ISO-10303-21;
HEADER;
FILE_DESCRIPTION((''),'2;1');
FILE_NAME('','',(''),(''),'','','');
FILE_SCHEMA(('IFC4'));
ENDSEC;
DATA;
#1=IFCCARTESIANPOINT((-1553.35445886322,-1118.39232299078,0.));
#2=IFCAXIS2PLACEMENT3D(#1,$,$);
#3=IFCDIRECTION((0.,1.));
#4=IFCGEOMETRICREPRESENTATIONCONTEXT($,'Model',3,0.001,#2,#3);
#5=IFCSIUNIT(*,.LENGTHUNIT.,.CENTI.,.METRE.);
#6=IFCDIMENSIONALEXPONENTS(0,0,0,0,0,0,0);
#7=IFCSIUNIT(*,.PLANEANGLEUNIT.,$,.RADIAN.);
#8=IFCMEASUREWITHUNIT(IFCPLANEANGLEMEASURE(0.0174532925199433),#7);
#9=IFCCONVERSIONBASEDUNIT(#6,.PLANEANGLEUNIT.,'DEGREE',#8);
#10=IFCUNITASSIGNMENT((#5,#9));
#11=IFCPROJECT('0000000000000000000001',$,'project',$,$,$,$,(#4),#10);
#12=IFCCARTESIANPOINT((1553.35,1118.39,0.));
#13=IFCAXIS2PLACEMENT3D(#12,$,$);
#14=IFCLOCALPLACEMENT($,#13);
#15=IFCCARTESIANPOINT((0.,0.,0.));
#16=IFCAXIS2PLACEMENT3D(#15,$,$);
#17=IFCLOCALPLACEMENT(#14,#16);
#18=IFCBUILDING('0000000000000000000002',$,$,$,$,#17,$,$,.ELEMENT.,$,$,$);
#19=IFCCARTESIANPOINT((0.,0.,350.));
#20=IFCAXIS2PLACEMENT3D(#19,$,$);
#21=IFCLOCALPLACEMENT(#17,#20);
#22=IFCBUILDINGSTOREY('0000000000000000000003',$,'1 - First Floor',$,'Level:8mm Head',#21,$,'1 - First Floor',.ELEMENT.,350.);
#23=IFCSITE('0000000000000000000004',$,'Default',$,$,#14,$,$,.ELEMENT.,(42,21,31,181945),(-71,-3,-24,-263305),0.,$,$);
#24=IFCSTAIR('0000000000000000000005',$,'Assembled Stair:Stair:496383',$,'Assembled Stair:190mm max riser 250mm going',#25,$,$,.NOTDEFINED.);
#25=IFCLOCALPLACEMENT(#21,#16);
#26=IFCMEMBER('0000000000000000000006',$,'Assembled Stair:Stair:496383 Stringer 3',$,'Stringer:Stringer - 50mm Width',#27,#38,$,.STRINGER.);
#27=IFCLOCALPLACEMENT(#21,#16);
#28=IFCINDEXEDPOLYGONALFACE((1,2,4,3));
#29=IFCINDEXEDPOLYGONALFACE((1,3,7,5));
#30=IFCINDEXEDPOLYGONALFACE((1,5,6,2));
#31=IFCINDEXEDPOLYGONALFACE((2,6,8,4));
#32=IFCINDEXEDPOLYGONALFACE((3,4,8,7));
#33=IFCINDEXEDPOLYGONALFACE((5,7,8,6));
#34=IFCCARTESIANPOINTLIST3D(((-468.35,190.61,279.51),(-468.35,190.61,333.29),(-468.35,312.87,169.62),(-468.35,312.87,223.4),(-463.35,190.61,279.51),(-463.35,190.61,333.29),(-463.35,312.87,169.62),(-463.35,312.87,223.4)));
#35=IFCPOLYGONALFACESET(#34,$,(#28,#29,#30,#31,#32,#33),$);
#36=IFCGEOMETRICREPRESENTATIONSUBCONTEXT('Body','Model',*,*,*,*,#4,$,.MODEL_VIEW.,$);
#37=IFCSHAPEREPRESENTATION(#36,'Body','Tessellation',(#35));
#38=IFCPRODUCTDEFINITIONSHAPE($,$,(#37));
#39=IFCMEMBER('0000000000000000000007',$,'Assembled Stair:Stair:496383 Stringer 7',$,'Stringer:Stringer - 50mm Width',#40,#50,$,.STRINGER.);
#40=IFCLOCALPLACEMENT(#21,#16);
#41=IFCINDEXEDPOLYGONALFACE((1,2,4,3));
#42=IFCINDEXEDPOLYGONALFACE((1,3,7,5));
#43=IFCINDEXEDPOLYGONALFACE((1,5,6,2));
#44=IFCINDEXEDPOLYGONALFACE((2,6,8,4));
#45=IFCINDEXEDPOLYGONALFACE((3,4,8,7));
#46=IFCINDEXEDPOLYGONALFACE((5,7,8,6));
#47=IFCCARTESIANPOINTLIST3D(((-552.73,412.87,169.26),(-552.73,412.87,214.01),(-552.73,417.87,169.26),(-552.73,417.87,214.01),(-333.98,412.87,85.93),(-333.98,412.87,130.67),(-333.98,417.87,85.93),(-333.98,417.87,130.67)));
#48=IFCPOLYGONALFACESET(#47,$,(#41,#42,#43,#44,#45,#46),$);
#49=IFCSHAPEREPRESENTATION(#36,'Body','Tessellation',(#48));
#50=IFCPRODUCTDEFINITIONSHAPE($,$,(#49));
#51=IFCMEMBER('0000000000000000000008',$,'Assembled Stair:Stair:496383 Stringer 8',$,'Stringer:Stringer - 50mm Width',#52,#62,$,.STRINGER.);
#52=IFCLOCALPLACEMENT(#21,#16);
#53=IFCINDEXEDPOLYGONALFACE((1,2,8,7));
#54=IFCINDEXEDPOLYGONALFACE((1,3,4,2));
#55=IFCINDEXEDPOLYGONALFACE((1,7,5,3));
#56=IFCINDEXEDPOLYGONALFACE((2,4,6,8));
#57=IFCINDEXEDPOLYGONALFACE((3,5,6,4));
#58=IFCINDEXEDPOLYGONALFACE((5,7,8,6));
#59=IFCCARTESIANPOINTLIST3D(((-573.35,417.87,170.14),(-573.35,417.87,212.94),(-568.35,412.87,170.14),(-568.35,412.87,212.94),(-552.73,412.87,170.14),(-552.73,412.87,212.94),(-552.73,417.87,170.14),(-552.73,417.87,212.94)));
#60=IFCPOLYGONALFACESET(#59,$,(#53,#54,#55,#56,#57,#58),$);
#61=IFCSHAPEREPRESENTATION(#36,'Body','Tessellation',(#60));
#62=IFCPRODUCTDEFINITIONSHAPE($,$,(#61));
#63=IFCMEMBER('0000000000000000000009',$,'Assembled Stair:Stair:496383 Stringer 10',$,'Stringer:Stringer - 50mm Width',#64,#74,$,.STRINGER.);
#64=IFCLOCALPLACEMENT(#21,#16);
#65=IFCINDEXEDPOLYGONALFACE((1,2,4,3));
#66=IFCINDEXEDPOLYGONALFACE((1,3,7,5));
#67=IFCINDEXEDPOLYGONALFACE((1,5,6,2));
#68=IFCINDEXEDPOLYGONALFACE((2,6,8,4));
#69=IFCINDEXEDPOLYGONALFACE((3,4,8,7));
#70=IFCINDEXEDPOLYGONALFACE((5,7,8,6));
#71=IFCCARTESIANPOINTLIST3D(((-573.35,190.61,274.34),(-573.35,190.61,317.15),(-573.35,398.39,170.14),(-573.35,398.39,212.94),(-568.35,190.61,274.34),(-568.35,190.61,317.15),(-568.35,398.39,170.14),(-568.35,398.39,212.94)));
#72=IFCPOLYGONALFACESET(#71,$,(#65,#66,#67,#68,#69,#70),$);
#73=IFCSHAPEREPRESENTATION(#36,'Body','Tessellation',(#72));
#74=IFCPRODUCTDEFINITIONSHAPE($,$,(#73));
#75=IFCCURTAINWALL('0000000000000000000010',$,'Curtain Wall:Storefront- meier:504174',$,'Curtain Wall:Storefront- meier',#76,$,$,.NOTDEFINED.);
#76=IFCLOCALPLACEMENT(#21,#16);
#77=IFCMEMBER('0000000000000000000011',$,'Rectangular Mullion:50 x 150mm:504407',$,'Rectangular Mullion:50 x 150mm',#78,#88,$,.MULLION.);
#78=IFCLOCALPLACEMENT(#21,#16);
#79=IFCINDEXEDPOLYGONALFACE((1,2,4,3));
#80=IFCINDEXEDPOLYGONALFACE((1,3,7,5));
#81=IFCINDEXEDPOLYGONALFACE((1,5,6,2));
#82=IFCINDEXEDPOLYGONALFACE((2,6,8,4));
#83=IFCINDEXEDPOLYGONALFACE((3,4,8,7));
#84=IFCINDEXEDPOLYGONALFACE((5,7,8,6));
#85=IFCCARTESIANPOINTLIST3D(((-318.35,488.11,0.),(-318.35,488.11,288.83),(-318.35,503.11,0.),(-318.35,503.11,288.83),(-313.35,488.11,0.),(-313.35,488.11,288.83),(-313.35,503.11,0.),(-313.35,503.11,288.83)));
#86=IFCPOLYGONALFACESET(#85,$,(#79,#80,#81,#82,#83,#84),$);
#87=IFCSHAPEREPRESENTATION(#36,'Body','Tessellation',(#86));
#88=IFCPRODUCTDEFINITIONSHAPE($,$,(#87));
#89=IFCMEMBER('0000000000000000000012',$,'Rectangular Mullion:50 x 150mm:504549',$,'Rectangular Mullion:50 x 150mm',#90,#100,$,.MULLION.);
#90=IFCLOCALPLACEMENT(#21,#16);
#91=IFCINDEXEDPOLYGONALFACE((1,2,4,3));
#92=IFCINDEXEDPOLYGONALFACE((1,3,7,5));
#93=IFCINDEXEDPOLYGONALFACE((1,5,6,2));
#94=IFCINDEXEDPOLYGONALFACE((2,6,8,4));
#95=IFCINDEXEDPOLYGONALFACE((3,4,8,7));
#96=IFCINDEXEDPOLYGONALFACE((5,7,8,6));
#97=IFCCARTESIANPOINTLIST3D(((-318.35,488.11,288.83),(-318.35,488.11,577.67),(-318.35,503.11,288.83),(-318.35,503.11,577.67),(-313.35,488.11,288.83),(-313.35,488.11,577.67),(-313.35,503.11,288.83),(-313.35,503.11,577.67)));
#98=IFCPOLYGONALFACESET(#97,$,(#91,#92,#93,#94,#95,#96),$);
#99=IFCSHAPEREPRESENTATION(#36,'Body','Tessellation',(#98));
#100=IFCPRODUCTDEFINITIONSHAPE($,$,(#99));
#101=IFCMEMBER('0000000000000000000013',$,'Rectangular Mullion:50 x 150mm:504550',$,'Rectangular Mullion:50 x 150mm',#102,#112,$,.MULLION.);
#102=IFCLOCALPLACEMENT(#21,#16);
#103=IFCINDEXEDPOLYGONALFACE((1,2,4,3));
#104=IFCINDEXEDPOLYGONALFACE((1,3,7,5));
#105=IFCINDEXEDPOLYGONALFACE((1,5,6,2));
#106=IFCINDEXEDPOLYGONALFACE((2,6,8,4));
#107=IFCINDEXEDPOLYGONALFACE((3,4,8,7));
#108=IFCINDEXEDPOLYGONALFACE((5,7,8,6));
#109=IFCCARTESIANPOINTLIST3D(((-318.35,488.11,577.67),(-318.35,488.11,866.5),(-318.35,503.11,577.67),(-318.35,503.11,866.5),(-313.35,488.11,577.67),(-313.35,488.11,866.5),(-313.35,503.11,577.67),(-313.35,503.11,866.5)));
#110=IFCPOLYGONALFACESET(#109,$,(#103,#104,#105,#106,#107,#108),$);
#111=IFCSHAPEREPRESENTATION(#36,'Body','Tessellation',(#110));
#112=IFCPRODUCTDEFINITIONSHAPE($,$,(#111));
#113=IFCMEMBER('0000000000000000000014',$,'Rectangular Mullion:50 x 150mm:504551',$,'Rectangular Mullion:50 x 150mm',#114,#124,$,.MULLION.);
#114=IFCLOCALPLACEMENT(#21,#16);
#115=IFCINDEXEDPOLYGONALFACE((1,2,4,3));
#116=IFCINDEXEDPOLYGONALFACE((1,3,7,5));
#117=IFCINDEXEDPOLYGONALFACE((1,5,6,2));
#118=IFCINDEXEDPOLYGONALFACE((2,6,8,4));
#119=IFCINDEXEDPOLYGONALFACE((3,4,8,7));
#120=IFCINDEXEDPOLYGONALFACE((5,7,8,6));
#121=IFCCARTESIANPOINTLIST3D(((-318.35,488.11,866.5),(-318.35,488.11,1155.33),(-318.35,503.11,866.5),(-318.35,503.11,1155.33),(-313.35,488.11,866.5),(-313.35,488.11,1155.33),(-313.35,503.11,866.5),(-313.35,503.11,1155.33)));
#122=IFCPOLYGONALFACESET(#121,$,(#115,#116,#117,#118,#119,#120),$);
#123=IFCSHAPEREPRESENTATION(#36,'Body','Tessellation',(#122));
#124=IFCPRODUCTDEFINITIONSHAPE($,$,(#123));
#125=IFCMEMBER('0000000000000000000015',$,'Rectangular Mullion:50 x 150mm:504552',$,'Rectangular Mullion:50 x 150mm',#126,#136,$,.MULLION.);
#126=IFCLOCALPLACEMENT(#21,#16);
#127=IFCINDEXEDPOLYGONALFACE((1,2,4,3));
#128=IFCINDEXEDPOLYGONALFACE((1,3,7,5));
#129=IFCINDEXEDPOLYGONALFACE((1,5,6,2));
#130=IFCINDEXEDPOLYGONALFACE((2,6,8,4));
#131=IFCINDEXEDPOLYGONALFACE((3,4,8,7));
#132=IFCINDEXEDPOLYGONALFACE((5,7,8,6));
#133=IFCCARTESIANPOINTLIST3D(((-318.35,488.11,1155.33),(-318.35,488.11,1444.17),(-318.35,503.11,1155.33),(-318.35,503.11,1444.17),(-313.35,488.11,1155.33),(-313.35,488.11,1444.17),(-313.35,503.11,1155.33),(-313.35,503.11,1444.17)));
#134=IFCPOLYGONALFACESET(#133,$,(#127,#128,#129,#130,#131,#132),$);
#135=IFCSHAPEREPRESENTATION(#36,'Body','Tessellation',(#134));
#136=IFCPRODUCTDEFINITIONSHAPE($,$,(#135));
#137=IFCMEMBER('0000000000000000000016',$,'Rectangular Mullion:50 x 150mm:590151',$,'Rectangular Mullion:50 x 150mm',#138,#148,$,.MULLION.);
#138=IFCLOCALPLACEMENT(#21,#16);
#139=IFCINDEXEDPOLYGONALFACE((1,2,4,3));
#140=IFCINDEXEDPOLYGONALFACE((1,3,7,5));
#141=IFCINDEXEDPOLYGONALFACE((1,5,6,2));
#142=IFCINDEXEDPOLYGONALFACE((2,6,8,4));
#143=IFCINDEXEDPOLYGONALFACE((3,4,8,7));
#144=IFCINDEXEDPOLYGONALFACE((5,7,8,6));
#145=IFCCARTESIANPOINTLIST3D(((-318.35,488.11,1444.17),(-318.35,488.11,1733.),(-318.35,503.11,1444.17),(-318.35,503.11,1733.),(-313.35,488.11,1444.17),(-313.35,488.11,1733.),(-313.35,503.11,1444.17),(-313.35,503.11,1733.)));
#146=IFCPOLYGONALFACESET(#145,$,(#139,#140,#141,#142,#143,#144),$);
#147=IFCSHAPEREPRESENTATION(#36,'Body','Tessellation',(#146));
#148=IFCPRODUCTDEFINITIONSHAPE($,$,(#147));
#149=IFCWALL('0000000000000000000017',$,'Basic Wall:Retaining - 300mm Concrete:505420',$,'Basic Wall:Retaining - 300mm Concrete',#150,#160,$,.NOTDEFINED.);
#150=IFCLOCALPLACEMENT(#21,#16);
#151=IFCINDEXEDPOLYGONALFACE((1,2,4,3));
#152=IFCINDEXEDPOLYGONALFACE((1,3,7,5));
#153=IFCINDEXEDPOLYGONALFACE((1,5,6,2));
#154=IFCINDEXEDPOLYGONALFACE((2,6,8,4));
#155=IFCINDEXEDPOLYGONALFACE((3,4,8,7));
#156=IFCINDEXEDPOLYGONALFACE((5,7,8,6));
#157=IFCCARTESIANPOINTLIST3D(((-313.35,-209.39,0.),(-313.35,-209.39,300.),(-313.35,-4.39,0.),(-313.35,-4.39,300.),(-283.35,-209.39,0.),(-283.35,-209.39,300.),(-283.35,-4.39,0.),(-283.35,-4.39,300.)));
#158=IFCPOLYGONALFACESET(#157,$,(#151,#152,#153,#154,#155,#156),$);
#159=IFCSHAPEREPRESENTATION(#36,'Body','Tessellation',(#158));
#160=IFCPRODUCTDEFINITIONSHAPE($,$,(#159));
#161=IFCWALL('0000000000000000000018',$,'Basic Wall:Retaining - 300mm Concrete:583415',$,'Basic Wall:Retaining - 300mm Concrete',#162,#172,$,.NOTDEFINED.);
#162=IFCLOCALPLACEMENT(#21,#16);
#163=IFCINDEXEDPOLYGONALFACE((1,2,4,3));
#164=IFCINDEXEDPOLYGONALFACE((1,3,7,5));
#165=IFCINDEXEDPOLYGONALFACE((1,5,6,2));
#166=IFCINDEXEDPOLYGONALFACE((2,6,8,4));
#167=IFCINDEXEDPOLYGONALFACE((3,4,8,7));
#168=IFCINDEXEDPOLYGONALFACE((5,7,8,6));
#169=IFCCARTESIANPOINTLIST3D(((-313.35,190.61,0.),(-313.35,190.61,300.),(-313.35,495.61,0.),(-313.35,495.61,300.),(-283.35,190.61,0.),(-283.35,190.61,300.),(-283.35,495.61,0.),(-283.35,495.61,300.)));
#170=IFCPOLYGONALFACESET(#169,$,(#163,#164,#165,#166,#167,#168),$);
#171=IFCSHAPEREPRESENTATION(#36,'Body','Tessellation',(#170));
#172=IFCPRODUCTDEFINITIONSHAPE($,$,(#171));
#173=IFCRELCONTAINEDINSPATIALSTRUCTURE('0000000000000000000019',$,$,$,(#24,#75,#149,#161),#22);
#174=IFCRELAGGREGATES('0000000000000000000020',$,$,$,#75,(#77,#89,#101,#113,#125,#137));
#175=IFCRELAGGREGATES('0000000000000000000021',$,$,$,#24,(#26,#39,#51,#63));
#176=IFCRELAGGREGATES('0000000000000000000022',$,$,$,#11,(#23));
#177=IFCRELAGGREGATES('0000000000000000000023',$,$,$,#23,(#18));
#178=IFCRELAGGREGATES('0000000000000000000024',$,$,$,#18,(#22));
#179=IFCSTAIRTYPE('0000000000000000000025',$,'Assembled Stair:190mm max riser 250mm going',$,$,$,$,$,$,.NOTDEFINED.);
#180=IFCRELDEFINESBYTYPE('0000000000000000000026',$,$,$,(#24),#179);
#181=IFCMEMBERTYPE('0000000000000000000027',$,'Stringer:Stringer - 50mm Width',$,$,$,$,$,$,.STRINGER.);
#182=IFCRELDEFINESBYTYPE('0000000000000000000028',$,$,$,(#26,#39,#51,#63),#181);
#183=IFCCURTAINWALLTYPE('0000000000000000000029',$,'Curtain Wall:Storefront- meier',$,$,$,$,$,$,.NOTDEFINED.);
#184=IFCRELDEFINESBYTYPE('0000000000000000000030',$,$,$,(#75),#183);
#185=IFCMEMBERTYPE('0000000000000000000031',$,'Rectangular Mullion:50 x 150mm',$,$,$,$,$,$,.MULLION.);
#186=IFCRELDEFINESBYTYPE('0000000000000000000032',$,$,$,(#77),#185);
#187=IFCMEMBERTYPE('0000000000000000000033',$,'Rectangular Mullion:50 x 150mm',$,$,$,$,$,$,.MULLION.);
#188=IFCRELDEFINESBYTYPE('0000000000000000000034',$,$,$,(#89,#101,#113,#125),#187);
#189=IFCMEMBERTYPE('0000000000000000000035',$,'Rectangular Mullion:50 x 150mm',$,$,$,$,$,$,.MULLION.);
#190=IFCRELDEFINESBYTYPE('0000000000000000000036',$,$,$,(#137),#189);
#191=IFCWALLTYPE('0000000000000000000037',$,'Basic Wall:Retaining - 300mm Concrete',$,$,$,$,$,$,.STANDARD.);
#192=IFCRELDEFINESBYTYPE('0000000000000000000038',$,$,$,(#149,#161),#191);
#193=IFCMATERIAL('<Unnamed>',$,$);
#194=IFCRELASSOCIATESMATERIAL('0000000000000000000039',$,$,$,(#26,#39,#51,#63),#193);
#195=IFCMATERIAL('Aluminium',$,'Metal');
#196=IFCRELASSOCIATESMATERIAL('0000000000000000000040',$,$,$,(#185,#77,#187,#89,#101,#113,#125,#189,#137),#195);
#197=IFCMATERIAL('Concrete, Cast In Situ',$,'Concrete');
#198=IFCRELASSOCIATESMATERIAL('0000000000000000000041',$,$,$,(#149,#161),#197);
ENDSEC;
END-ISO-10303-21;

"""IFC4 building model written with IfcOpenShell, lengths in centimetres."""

from ifc_helpers import new_model, entity, si_unit, converted_unit, direction, frame, origin, place, context, subcontext, project, spatial, indexed_curve, outline, extrude, source, transform, mapped, material, type_object, type_shapes, element, aggregate, save


model = new_model("IFC4")

# Units and contexts
model_context = context("Model", 3, precision=0.001, world=frame((-1553.35445886322, -1118.39232299078, 0.0)), true_north=direction((0.0, 1.0)))
body_context = subcontext(model_context, "Body", "Model", "MODEL_VIEW")
ifc_project = project(units=[si_unit("LENGTHUNIT", "METRE", prefix="CENTI"), converted_unit("PLANEANGLEUNIT", "DEGREE", entity("IfcPlaneAngleMeasure", 0.0174532925199433), si_unit("PLANEANGLEUNIT", "RADIAN"), dimensions=[0, 0, 0, 0, 0, 0, 0])], contexts=[model_context])

# Site, building, storey
site_placement = place(None, frame((1553.35, 1118.39, 0.0)))
site = spatial("IfcSite", under=ifc_project, at=site_placement, Name="Default", CompositionType="ELEMENT", RefLatitude=(42, 21, 31, 181945), RefLongitude=(-71, -3, -24, -263305), RefElevation=0.0)
building_placement = place(site_placement, origin())
building = spatial("IfcBuilding", under=site, at=building_placement, CompositionType="ELEMENT")
storey_placement = place(building_placement, frame((0.0, 0.0, 350.0)))
storey = spatial("IfcBuildingStorey", under=building, at=storey_placement, Name="1 - First Floor", ObjectType="Level:8mm Head", LongName="1 - First Floor", CompositionType="ELEMENT", Elevation=350.0)

# Stair, members
stair_type = type_object("IfcStairType", Name="Assembled Stair:190mm max riser 250mm going", PredefinedType="NOTDEFINED")
stair_1_placement = place(storey_placement, origin())
stair_1 = element("IfcStair", 1, at=stair_1_placement, inside=storey, type_object=stair_type, Name="Assembled Stair:Stair:496383", ObjectType="Assembled Stair:190mm max riser 250mm going", PredefinedType="NOTDEFINED")
ifc_material_1 = material(Name="<Unnamed>")
member_type_1 = type_object("IfcMemberType", Name="Stringer:Stringer - 50mm Width", PredefinedType="STRINGER")
member_1_placement = place(stair_1_placement, origin())
member_1 = element("IfcMember", 2, at=member_1_placement, type_object=member_type_1, material=ifc_material_1, Name="Assembled Stair:Stair:496383 Stringer 3", ObjectType="Stringer:Stringer - 50mm Width", PredefinedType="STRINGER", context=body_context, shape_type="SweptSolid", body=[
    extrude(outline(indexed_curve([(-64.22, -20.0), (100.17, -20.0), (64.22, 20.0), (-100.17, 20.0), (-64.22, -20.0)], self_intersect=False)), frame((-468.35, 251.74, 251.46), z_axis=(1.0, 0.0, 0.0), x_axis=(0.0, -0.74373, 0.668481)), (0.0, 0.0, 1.0), 5.0),
])
member_2_placement = place(stair_1_placement, origin())
member_2 = element("IfcMember", 3, at=member_2_placement, type_object=member_type_1, material=ifc_material_1, Name="Assembled Stair:Stair:496383 Stringer 7", ObjectType="Stringer:Stringer - 50mm Width", PredefinedType="STRINGER", context=body_context, shape_type="SweptSolid", body=[
    extrude(outline(indexed_curve([(-125.01, -20.91), (109.08, -20.91), (125.01, 20.91), (-109.08, 20.91), (-125.01, -20.91)], self_intersect=False)), frame((-443.35, 412.87, 149.97), z_axis=(0.0, 1.0, 0.0), x_axis=(-0.934489, 0.0, 0.355992)), (0.0, 0.0, 1.0), 5.0),
])
member_3_placement = place(stair_1_placement, origin())
member_3 = element("IfcMember", 4, at=member_3_placement, type_object=member_type_1, material=ifc_material_1, Name="Assembled Stair:Stair:496383 Stringer 8", ObjectType="Stringer:Stringer - 50mm Width", PredefinedType="STRINGER", context=body_context, shape_type="SweptSolid", body=[
    extrude(outline(indexed_curve([(-9.06, -2.5), (11.56, -2.5), (6.56, 2.5), (-9.06, 2.5), (-9.06, -2.5)], self_intersect=False)), frame((-561.79, 415.37, 170.14), z_axis=(0.0, 0.0, 1.0), x_axis=(-1.0, 0.0, 0.0)), (0.0, 0.0, 1.0), 42.8),
])
member_4_placement = place(stair_1_placement, origin())
member_4 = element("IfcMember", 5, at=member_4_placement, type_object=member_type_1, material=ifc_material_1, Name="Assembled Stair:Stair:496383 Stringer 10", ObjectType="Stringer:Stringer - 50mm Width", PredefinedType="STRINGER", context=body_context, shape_type="SweptSolid", body=[
    extrude(outline(indexed_curve([(-106.63, -19.13), (125.82, -19.13), (106.63, 19.13), (-125.82, 19.13), (-106.63, -19.13)], self_intersect=False)), frame((-573.35, 294.5, 243.64), z_axis=(1.0, 0.0, 0.0), x_axis=(0.0, -0.893886, 0.448294)), (0.0, 0.0, 1.0), 5.0),
])

# Curtain wall, members
curtain_wall_type = type_object("IfcCurtainWallType", Name="Curtain Wall:Storefront- meier", PredefinedType="NOTDEFINED")
curtain_wall_placement = place(storey_placement, frame((0.0, 0.0, -350.0)))
curtain_wall = element("IfcCurtainWall", 6, at=curtain_wall_placement, inside=storey, type_object=curtain_wall_type, Name="Curtain Wall:Storefront- meier:504174", ObjectType="Curtain Wall:Storefront- meier", PredefinedType="NOTDEFINED")
ifc_material_2 = material(Name="Aluminium", Category="Metal")
member_type_2 = type_object("IfcMemberType", Name="Rectangular Mullion:50 x 150mm", PredefinedType="MULLION", material=ifc_material_2)
shared_shape_1 = source(origin(), body_context, "Body", "SweptSolid", [
    extrude(outline(indexed_curve([(-2.5, -7.5), (2.5, -7.5), (2.5, 7.5), (-2.5, 7.5), (-2.5, -7.5)], self_intersect=False)), frame((-2.5, 0.0, -288.83), z_axis=(0.0, 0.0, 1.0), x_axis=(-1.0, 0.0, 0.0)), (0.0, 0.0, 1.0), 288.83),
])
type_shapes(member_type_2, [shared_shape_1])
member_5_placement = place(curtain_wall_placement, frame((-313.35, 495.61, 350.0), z_axis=(0.0, 0.0, -1.0), x_axis=(1.0, 0.0, 0.0)))
member_5 = element("IfcMember", 7, at=member_5_placement, type_object=member_type_2, material=ifc_material_2, Name="Rectangular Mullion:50 x 150mm:504407", ObjectType="Rectangular Mullion:50 x 150mm", PredefinedType="MULLION", context=body_context, shape_type="MappedRepresentation", body=[
    mapped(shared_shape_1, transform((0.0, 0.0, 0.0), scale=1.0)),
])
member_type_3 = type_object("IfcMemberType", Name="Rectangular Mullion:50 x 150mm", PredefinedType="MULLION", material=ifc_material_2)
shared_shape_2 = source(origin(), body_context, "Body", "SweptSolid", [
    extrude(outline(indexed_curve([(-2.5, -7.5), (2.5, -7.5), (2.5, 7.5), (-2.5, 7.5), (-2.5, -7.5)], self_intersect=False)), frame((-2.5, 0.0, -288.83), z_axis=(0.0, 0.0, 1.0), x_axis=(-1.0, 0.0, 0.0)), (0.0, 0.0, 1.0), 288.83),
])
type_shapes(member_type_3, [shared_shape_2])
member_6_placement = place(curtain_wall_placement, frame((-313.35, 495.61, 638.83), z_axis=(0.0, 0.0, -1.0), x_axis=(1.0, 0.0, 0.0)))
member_6 = element("IfcMember", 8, at=member_6_placement, type_object=member_type_3, material=ifc_material_2, Name="Rectangular Mullion:50 x 150mm:504549", ObjectType="Rectangular Mullion:50 x 150mm", PredefinedType="MULLION", context=body_context, shape_type="MappedRepresentation", body=[
    mapped(shared_shape_2, transform((0.0, 0.0, 0.0), scale=1.0)),
])
member_7_placement = place(curtain_wall_placement, frame((-313.35, 495.61, 927.67), z_axis=(0.0, 0.0, -1.0), x_axis=(1.0, 0.0, 0.0)))
member_7 = element("IfcMember", 9, at=member_7_placement, type_object=member_type_3, material=ifc_material_2, Name="Rectangular Mullion:50 x 150mm:504550", ObjectType="Rectangular Mullion:50 x 150mm", PredefinedType="MULLION", context=body_context, shape_type="MappedRepresentation", body=[
    mapped(shared_shape_2, transform((0.0, 0.0, 0.0), scale=1.0)),
])
member_8_placement = place(curtain_wall_placement, frame((-313.35, 495.61, 1216.5), z_axis=(0.0, 0.0, -1.0), x_axis=(1.0, 0.0, 0.0)))
member_8 = element("IfcMember", 10, at=member_8_placement, type_object=member_type_3, material=ifc_material_2, Name="Rectangular Mullion:50 x 150mm:504551", ObjectType="Rectangular Mullion:50 x 150mm", PredefinedType="MULLION", context=body_context, shape_type="MappedRepresentation", body=[
    mapped(shared_shape_2, transform((0.0, 0.0, 0.0), scale=1.0)),
])
member_9_placement = place(curtain_wall_placement, frame((-313.35, 495.61, 1505.33), z_axis=(0.0, 0.0, -1.0), x_axis=(1.0, 0.0, 0.0)))
member_9 = element("IfcMember", 11, at=member_9_placement, type_object=member_type_3, material=ifc_material_2, Name="Rectangular Mullion:50 x 150mm:504552", ObjectType="Rectangular Mullion:50 x 150mm", PredefinedType="MULLION", context=body_context, shape_type="MappedRepresentation", body=[
    mapped(shared_shape_2, transform((0.0, 0.0, 0.0), scale=1.0)),
])
member_type_4 = type_object("IfcMemberType", Name="Rectangular Mullion:50 x 150mm", PredefinedType="MULLION", material=ifc_material_2)
shared_shape_3 = source(origin(), body_context, "Body", "SweptSolid", [
    extrude(outline(indexed_curve([(-2.5, -7.5), (2.5, -7.5), (2.5, 7.5), (-2.5, 7.5), (-2.5, -7.5)], self_intersect=False)), frame((-2.5, 0.0, -288.83), z_axis=(0.0, 0.0, 1.0), x_axis=(-1.0, 0.0, 0.0)), (0.0, 0.0, 1.0), 288.83),
])
type_shapes(member_type_4, [shared_shape_3])
member_10_placement = place(curtain_wall_placement, frame((-313.35, 495.61, 1794.17), z_axis=(0.0, 0.0, -1.0), x_axis=(1.0, 0.0, 0.0)))
member_10 = element("IfcMember", 12, at=member_10_placement, type_object=member_type_4, material=ifc_material_2, Name="Rectangular Mullion:50 x 150mm:590151", ObjectType="Rectangular Mullion:50 x 150mm", PredefinedType="MULLION", context=body_context, shape_type="MappedRepresentation", body=[
    mapped(shared_shape_3, transform((0.0, 0.0, 0.0), scale=1.0)),
])
aggregate(curtain_wall, [member_5, member_6, member_7, member_8, member_9, member_10])

# Walls
ifc_material_3 = material(Name="Concrete, Cast In Situ", Category="Concrete")
wall_type_1 = type_object("IfcWallType", Name="Basic Wall:Retaining - 300mm Concrete", PredefinedType="STANDARD")
wall_1_placement = place(storey_placement, frame((-298.35, -209.39, 0.0), z_axis=(0.0, 0.0, 1.0), x_axis=(0.0, 1.0, 0.0)))
element("IfcWall", 13, at=wall_1_placement, inside=storey, type_object=wall_type_1, material=ifc_material_3, Name="Basic Wall:Retaining - 300mm Concrete:505420", ObjectType="Basic Wall:Retaining - 300mm Concrete", PredefinedType="NOTDEFINED", context=body_context, shape_type="SweptSolid", body=[
    extrude(outline(indexed_curve([(205.0, 15.0), (0.0, 15.0), (0.0, -15.0), (205.0, -15.0), (205.0, 15.0)], self_intersect=False)), origin(), (0.0, 0.0, 1.0), 300.0),
])
wall_2_placement = place(storey_placement, frame((-298.35, 495.61, 0.0), z_axis=(0.0, 0.0, 1.0), x_axis=(0.0, -1.0, 0.0)))
element("IfcWall", 14, at=wall_2_placement, inside=storey, type_object=wall_type_1, material=ifc_material_3, Name="Basic Wall:Retaining - 300mm Concrete:583415", ObjectType="Basic Wall:Retaining - 300mm Concrete", PredefinedType="NOTDEFINED", context=body_context, shape_type="SweptSolid", body=[
    extrude(outline(indexed_curve([(305.0, 15.0), (0.0, 15.0), (0.0, -15.0), (305.0, -15.0), (305.0, 15.0)], self_intersect=False)), origin(), (0.0, 0.0, 1.0), 300.0),
])

aggregate(stair_1, [member_1, member_2, member_3, member_4])

save(model, "model.ifc")
